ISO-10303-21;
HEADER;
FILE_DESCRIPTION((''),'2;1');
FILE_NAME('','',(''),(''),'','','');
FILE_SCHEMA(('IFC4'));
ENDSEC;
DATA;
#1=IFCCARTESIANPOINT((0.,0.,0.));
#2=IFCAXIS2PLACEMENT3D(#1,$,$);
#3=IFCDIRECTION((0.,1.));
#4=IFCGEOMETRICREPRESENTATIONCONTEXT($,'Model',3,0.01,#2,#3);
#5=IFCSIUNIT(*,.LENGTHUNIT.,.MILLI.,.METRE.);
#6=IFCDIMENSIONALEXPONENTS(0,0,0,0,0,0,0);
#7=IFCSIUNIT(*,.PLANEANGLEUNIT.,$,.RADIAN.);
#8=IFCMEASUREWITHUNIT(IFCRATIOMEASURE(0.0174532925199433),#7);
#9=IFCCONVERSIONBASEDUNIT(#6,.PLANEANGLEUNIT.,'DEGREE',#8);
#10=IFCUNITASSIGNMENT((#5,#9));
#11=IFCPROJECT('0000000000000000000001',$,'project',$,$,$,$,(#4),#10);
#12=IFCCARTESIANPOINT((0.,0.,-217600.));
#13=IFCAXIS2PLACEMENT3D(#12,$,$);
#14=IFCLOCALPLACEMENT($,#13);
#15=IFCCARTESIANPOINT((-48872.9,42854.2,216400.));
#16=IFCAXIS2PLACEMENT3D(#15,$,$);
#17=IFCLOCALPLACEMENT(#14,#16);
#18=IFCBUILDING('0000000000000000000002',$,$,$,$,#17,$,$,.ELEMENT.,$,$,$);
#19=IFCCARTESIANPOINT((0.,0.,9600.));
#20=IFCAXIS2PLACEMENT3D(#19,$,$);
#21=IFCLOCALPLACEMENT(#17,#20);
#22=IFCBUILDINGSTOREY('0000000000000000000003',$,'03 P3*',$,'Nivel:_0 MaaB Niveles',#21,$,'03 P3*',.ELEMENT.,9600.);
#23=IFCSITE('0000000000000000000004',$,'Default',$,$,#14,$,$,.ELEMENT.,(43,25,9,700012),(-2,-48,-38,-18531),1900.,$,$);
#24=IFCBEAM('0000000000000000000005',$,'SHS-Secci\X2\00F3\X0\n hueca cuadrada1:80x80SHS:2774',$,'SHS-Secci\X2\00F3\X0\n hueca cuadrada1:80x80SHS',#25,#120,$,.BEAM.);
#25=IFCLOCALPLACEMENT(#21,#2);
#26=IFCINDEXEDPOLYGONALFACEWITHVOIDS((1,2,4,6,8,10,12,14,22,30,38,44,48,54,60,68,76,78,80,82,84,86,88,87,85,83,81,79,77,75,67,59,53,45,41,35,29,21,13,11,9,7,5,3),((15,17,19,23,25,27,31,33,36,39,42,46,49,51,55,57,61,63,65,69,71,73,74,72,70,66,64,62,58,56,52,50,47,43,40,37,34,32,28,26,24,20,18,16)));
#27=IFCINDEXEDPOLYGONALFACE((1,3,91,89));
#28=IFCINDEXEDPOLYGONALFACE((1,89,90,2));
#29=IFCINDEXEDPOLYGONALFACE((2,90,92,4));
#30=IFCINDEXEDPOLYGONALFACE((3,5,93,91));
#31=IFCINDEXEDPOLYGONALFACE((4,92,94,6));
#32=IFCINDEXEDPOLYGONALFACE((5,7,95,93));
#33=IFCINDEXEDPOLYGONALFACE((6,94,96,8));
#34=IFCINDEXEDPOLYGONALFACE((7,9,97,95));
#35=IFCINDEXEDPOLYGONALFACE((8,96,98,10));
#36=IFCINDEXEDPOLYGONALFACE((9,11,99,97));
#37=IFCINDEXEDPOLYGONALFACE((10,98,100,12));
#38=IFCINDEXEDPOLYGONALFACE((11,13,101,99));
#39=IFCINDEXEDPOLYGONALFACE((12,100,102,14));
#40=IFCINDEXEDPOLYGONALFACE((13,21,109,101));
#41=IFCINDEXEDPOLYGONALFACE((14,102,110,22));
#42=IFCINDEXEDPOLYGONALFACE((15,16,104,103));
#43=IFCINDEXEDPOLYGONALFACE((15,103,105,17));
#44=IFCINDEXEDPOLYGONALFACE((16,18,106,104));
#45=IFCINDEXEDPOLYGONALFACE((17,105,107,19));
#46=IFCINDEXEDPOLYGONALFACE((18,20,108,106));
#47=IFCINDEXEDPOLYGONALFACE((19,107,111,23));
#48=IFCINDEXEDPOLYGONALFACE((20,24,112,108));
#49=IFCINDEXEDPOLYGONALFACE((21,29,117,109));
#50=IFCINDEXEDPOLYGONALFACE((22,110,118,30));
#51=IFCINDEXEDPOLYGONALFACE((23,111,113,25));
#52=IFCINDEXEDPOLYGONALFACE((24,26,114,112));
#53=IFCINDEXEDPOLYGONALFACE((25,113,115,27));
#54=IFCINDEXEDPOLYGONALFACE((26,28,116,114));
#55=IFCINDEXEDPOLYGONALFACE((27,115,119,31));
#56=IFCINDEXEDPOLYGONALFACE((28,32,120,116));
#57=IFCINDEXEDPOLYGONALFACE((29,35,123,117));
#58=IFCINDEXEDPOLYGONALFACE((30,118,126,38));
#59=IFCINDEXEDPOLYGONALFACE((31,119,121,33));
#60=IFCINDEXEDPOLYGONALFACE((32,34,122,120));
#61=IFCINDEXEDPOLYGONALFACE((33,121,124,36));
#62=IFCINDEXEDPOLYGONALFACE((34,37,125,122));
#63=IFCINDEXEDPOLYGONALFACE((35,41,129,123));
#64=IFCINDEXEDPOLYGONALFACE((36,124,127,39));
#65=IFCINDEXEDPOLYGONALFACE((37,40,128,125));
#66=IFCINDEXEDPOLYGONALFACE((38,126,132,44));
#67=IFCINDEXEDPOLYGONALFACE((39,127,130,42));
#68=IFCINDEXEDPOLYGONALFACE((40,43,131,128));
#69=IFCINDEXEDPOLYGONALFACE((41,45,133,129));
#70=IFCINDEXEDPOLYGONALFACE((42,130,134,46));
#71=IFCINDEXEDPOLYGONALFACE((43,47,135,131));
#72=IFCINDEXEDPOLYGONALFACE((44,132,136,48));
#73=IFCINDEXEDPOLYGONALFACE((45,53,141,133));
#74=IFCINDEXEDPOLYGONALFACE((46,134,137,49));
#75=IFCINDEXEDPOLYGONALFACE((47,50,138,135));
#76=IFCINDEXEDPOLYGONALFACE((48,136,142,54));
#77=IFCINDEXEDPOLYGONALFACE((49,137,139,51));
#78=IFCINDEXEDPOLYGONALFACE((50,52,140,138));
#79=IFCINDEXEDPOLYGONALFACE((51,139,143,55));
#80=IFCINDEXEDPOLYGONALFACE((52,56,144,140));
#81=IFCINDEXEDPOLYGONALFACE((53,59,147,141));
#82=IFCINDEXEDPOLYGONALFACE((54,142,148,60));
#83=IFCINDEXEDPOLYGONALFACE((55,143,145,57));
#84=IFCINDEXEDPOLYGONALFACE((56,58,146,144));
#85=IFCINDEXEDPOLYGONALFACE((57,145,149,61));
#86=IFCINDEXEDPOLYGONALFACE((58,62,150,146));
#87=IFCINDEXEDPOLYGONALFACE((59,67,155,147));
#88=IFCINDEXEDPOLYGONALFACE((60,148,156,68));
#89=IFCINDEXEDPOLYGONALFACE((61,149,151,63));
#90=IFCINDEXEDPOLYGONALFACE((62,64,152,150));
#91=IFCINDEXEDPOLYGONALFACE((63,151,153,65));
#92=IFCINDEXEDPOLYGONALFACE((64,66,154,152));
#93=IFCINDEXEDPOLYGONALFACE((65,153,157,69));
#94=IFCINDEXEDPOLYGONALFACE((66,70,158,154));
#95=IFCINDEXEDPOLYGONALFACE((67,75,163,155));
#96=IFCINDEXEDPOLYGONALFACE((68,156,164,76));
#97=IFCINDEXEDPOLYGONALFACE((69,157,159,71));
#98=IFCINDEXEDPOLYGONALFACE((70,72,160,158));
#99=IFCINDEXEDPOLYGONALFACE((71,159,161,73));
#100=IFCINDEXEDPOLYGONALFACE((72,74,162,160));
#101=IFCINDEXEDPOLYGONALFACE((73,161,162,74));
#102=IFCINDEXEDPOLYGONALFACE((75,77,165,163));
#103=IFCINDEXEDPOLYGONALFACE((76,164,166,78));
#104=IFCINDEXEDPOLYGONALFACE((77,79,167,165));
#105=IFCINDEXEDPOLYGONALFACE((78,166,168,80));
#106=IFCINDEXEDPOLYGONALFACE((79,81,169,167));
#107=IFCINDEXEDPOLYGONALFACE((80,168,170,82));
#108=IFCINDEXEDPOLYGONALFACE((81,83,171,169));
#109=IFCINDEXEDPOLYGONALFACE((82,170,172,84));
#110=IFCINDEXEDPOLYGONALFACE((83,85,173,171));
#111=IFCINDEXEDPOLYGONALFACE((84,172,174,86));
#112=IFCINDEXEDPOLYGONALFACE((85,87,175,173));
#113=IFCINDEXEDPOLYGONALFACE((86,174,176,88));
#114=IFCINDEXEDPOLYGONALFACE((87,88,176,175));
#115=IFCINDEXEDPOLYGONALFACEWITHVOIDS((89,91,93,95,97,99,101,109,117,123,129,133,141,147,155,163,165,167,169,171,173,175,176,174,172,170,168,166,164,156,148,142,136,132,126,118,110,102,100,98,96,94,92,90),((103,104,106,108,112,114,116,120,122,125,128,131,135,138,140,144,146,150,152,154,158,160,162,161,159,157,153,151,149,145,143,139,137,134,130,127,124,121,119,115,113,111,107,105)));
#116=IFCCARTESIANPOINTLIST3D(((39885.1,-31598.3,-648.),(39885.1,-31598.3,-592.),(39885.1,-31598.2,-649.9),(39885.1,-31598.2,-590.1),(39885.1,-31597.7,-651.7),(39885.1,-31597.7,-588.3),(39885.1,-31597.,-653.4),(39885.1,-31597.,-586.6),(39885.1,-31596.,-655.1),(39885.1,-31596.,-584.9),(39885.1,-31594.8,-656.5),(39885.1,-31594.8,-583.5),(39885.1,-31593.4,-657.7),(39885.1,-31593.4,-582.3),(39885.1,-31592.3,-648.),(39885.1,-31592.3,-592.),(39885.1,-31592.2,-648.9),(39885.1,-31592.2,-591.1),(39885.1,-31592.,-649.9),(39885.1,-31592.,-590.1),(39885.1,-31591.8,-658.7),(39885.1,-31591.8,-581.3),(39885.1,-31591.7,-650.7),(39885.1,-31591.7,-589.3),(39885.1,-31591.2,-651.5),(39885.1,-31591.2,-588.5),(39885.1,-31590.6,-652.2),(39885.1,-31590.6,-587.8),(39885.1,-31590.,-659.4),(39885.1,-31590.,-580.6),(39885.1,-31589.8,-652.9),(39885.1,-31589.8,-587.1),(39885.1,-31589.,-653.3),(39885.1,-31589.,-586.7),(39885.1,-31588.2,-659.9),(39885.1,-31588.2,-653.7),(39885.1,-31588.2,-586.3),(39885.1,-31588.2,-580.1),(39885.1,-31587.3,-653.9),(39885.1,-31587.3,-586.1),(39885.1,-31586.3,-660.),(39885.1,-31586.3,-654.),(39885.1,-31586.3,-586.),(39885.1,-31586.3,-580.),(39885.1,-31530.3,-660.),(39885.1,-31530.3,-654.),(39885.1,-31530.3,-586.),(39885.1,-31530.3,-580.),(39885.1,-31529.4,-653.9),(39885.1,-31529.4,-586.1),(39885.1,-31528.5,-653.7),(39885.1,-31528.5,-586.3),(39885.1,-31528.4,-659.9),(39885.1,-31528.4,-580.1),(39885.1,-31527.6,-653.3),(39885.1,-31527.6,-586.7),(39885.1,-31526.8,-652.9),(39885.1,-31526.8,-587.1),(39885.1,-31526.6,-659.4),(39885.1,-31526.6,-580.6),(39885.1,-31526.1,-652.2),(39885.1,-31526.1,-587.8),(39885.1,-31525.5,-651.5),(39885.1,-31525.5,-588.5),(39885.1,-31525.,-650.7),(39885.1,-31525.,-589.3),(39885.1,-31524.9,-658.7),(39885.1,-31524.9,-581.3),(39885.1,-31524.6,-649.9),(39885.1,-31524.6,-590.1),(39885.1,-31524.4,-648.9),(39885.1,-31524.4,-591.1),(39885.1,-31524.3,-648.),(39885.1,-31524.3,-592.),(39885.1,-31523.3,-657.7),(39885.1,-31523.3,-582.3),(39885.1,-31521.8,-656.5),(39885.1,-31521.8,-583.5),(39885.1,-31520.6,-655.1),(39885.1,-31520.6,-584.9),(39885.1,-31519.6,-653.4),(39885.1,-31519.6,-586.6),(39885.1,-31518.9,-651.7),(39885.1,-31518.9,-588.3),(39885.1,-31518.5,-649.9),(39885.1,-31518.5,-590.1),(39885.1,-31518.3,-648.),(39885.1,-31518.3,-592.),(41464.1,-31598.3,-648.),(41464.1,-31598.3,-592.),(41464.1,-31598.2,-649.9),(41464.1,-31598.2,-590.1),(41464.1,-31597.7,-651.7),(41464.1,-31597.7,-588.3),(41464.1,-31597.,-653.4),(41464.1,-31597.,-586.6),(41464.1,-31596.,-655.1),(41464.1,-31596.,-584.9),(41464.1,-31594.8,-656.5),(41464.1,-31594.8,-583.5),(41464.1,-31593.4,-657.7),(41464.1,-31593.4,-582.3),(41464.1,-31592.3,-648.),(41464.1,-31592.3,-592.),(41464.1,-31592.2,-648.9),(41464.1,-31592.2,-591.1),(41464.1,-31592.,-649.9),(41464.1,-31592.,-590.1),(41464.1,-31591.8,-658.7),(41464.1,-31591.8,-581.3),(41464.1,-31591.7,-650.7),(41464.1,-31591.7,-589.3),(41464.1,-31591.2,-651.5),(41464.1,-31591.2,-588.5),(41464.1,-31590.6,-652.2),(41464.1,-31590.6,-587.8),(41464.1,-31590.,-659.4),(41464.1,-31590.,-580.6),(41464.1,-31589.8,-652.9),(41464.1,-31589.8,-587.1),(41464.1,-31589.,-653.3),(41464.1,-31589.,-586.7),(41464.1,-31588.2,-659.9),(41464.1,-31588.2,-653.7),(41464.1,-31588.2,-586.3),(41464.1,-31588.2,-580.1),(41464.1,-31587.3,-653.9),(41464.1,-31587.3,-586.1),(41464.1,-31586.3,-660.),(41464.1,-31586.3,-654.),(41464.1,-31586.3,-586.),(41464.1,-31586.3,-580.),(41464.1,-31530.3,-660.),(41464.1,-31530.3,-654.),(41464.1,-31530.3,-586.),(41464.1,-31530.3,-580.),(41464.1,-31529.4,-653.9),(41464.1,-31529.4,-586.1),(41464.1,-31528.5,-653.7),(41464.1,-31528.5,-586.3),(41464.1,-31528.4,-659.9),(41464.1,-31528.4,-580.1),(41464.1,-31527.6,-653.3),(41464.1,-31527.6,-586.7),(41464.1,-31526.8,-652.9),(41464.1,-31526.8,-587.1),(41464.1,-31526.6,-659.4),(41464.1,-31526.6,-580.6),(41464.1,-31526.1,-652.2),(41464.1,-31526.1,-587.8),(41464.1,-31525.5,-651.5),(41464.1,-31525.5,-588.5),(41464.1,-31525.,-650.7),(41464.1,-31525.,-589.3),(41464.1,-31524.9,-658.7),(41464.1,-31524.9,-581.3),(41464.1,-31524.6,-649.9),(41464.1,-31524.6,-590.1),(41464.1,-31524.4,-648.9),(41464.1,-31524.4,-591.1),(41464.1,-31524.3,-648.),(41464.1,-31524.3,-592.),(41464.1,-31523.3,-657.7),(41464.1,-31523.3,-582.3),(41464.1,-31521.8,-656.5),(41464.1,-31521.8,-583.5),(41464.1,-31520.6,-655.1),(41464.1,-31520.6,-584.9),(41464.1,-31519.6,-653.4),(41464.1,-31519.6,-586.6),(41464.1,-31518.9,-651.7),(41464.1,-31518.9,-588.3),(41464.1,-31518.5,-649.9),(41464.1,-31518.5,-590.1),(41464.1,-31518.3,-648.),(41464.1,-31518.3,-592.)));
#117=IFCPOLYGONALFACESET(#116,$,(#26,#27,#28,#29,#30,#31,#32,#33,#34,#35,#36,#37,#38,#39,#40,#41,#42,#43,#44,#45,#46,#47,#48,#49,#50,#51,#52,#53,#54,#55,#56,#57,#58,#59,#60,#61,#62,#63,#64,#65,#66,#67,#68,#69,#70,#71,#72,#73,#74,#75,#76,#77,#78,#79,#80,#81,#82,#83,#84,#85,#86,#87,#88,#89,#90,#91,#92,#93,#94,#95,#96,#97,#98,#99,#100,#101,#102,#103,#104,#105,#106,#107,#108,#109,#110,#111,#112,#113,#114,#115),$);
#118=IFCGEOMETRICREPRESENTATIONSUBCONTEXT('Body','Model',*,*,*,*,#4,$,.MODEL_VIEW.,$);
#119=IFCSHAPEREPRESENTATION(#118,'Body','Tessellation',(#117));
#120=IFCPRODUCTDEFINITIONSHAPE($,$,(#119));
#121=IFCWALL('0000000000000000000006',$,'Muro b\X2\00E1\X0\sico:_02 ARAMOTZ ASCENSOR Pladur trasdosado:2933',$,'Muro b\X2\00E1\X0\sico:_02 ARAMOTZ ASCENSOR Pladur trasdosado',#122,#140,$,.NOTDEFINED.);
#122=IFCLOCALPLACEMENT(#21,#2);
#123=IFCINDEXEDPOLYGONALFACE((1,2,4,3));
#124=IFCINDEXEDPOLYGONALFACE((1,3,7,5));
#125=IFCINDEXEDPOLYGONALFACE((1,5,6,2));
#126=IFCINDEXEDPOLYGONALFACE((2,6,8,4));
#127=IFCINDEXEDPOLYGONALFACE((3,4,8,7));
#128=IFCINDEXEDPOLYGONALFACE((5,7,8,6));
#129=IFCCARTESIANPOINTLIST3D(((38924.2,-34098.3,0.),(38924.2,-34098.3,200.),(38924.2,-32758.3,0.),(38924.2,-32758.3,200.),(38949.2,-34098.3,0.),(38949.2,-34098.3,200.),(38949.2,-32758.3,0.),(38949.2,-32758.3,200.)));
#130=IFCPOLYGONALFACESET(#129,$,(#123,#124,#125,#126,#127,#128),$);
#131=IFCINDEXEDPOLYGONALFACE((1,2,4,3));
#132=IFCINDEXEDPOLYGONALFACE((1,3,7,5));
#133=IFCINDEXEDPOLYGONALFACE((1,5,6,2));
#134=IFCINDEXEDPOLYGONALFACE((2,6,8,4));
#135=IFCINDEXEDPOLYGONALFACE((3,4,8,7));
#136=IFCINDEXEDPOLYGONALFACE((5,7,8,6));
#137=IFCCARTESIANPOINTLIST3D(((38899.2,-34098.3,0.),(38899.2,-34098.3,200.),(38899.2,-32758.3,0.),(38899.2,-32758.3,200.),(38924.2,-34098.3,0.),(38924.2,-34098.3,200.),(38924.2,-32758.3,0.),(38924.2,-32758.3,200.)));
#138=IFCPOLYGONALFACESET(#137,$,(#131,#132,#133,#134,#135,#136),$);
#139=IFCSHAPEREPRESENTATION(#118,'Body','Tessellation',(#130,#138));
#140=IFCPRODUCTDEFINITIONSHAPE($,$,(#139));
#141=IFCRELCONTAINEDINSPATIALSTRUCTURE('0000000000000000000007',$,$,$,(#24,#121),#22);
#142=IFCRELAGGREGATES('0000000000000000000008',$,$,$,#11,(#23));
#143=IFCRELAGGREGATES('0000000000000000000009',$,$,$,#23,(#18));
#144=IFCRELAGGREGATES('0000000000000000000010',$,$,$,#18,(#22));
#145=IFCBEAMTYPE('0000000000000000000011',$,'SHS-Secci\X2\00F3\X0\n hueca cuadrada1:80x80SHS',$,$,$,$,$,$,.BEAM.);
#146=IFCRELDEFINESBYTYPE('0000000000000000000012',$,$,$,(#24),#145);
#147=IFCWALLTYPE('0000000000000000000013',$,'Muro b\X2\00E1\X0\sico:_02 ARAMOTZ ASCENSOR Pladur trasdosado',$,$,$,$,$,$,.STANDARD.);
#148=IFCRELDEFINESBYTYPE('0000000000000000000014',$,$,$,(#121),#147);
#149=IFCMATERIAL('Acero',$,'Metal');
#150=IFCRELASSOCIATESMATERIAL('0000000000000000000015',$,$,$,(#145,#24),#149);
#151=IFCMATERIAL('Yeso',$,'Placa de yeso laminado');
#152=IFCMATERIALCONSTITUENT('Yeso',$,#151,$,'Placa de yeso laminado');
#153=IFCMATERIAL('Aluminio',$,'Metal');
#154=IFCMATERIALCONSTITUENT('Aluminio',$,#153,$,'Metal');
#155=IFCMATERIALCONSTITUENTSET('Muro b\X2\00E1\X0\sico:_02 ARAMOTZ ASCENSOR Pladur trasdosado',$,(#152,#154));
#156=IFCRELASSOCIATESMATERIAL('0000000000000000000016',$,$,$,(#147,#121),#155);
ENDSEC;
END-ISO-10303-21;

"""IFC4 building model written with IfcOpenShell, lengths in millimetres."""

from ifc_helpers import new_model, entity, si_unit, converted_unit, direction, frame, origin, place, context, subcontext, project, spatial, indexed_curve, outline, extrude, source, transform, mapped, material, constituent, constituent_set, type_object, type_shapes, element, save


model = new_model("IFC4")

# Units and contexts
model_context = context("Model", 3, precision=0.01, world=origin(), true_north=direction((0.0, 1.0)))
body_context = subcontext(model_context, "Body", "Model", "MODEL_VIEW")
ifc_project = project(units=[si_unit("LENGTHUNIT", "METRE", prefix="MILLI"), converted_unit("PLANEANGLEUNIT", "DEGREE", entity("IfcRatioMeasure", 0.0174532925199433), si_unit("PLANEANGLEUNIT", "RADIAN"), dimensions=[0, 0, 0, 0, 0, 0, 0])], contexts=[model_context])

# Site, building, storey
site_placement = place(None, frame((0.0, 0.0, -217600.0)))
site = spatial("IfcSite", under=ifc_project, at=site_placement, Name="Default", CompositionType="ELEMENT", RefLatitude=(43, 25, 9, 700012), RefLongitude=(-2, -48, -38, -18531), RefElevation=1900.0)
building_placement = place(site_placement, frame((-48872.9, 42854.2, 216400.0)))
building = spatial("IfcBuilding", under=site, at=building_placement, CompositionType="ELEMENT")
storey_placement = place(building_placement, frame((0.0, 0.0, 9600.0)))
storey = spatial("IfcBuildingStorey", under=building, at=storey_placement, Name="03 P3*", ObjectType="Nivel:_0 MaaB Niveles", LongName="03 P3*", CompositionType="ELEMENT", Elevation=9600.0)

# Shared definitions
ifc_material_1 = material(Name="Acero", Category="Metal")

# Beam
beam_type = type_object("IfcBeamType", Name="SHS-Sección hueca cuadrada1:80x80SHS", PredefinedType="BEAM", material=ifc_material_1)
shared_shape_1 = source(origin(), body_context, "Body", "SweptSolid", [
    extrude(outline(indexed_curve([(-40.0, -28.0), (-39.9, -29.9), (-39.4, -31.7), (-38.7, -33.4), (-37.7, -35.1), (-36.5, -36.5), (-35.1, -37.7), (-33.4, -38.7), (-31.7, -39.4), (-29.9, -39.9), (-28.0, -40.0), (28.0, -40.0), (29.9, -39.9), (31.7, -39.4), (33.4, -38.7), (35.1, -37.7), (36.5, -36.5), (37.7, -35.1), (38.7, -33.4), (39.4, -31.7), (39.9, -29.9), (40.0, -28.0), (40.0, 28.0), (39.9, 29.9), (39.4, 31.7), (38.7, 33.4), (37.7, 35.1), (36.5, 36.5), (35.1, 37.7), (33.4, 38.7), (31.7, 39.4), (29.9, 39.9), (28.0, 40.0), (-28.0, 40.0), (-29.9, 39.9), (-31.7, 39.4), (-33.4, 38.7), (-35.1, 37.7), (-36.5, 36.5), (-37.7, 35.1), (-38.7, 33.4), (-39.4, 31.7), (-39.9, 29.9), (-40.0, 28.0), (-40.0, -28.0)], self_intersect=False), holes=[indexed_curve([(28.0, -34.0), (-28.0, -34.0), (-28.9, -33.9), (-29.9, -33.7), (-30.7, -33.3), (-31.5, -32.9), (-32.2, -32.2), (-32.9, -31.5), (-33.3, -30.7), (-33.7, -29.9), (-33.9, -28.9), (-34.0, -28.0), (-34.0, 28.0), (-33.9, 28.9), (-33.7, 29.9), (-33.3, 30.7), (-32.9, 31.5), (-32.2, 32.2), (-31.5, 32.9), (-30.7, 33.3), (-29.9, 33.7), (-28.9, 33.9), (-28.0, 34.0), (28.0, 34.0), (28.9, 33.9), (29.9, 33.7), (30.7, 33.3), (31.5, 32.9), (32.2, 32.2), (32.9, 31.5), (33.3, 30.7), (33.7, 29.9), (33.9, 28.9), (34.0, 28.0), (34.0, -28.0), (33.9, -28.9), (33.7, -29.9), (33.3, -30.7), (32.9, -31.5), (32.2, -32.2), (31.5, -32.9), (30.7, -33.3), (29.9, -33.7), (28.9, -33.9), (28.0, -34.0)], self_intersect=False)]), frame((-733.0, 0.0, 0.0), z_axis=(1.0, 0.0, 0.0), x_axis=(0.0, -1.0, 0.0)), (0.0, 0.0, 1.0), 1579.0),
])
type_shapes(beam_type, [shared_shape_1])
beam_placement = place(storey_placement, frame((40731.1, -31558.3, -620.0), z_axis=(0.0, 0.0, 1.0), x_axis=(-1.0, 0.0, 0.0)))
element("IfcBeam", 1, at=beam_placement, inside=storey, type_object=beam_type, material=ifc_material_1, Name="SHS-Sección hueca cuadrada1:80x80SHS:2774", ObjectType="SHS-Sección hueca cuadrada1:80x80SHS", PredefinedType="BEAM", context=body_context, shape_type="MappedRepresentation", body=[
    mapped(shared_shape_1, transform((0.0, 0.0, 0.0), scale=1.0)),
])

# Wall
ifc_material_2 = material(Name="Yeso", Category="Placa de yeso laminado")
ifc_material_3 = material(Name="Aluminio", Category="Metal")
ifc_constituent_1 = constituent(ifc_material_2, Name="Yeso", Category="Placa de yeso laminado")
ifc_constituent_2 = constituent(ifc_material_3, Name="Aluminio", Category="Metal")
ifc_constituent_set_1 = constituent_set(constituents=[ifc_constituent_1, ifc_constituent_2], Name="Muro básico:_02 ARAMOTZ ASCENSOR Pladur trasdosado")
wall_type_1 = type_object("IfcWallType", Name="Muro básico:_02 ARAMOTZ ASCENSOR Pladur trasdosado", PredefinedType="STANDARD", material=ifc_constituent_set_1)
wall_1_placement = place(storey_placement, frame((38924.2, -32758.3, 0.0), z_axis=(0.0, 0.0, 1.0), x_axis=(0.0, -1.0, 0.0)))
element("IfcWall", 2, at=wall_1_placement, inside=storey, type_object=wall_type_1, material=ifc_constituent_set_1, Name="Muro básico:_02 ARAMOTZ ASCENSOR Pladur trasdosado:2933", ObjectType="Muro básico:_02 ARAMOTZ ASCENSOR Pladur trasdosado", PredefinedType="NOTDEFINED", context=body_context, shape_type="SweptSolid", body=[
    extrude(outline(indexed_curve([(-670.0, -12.5), (670.0, -12.5), (670.0, 12.5), (-670.0, 12.5), (-670.0, -12.5)], self_intersect=False)), frame((670.0, 12.5, 0.0), z_axis=(0.0, 0.0, 1.0), x_axis=(-1.0, 0.0, 0.0)), (0.0, 0.0, 1.0), 200.0),
    extrude(outline(indexed_curve([(-12.5, -670.0), (12.5, -670.0), (12.5, 670.0), (-12.5, 670.0), (-12.5, -670.0)], self_intersect=False)), frame((670.0, -12.5, 0.0), z_axis=(0.0, 0.0, 1.0), x_axis=(0.0, -1.0, 0.0)), (0.0, 0.0, 1.0), 200.0),
])

save(model, "model.ifc")
